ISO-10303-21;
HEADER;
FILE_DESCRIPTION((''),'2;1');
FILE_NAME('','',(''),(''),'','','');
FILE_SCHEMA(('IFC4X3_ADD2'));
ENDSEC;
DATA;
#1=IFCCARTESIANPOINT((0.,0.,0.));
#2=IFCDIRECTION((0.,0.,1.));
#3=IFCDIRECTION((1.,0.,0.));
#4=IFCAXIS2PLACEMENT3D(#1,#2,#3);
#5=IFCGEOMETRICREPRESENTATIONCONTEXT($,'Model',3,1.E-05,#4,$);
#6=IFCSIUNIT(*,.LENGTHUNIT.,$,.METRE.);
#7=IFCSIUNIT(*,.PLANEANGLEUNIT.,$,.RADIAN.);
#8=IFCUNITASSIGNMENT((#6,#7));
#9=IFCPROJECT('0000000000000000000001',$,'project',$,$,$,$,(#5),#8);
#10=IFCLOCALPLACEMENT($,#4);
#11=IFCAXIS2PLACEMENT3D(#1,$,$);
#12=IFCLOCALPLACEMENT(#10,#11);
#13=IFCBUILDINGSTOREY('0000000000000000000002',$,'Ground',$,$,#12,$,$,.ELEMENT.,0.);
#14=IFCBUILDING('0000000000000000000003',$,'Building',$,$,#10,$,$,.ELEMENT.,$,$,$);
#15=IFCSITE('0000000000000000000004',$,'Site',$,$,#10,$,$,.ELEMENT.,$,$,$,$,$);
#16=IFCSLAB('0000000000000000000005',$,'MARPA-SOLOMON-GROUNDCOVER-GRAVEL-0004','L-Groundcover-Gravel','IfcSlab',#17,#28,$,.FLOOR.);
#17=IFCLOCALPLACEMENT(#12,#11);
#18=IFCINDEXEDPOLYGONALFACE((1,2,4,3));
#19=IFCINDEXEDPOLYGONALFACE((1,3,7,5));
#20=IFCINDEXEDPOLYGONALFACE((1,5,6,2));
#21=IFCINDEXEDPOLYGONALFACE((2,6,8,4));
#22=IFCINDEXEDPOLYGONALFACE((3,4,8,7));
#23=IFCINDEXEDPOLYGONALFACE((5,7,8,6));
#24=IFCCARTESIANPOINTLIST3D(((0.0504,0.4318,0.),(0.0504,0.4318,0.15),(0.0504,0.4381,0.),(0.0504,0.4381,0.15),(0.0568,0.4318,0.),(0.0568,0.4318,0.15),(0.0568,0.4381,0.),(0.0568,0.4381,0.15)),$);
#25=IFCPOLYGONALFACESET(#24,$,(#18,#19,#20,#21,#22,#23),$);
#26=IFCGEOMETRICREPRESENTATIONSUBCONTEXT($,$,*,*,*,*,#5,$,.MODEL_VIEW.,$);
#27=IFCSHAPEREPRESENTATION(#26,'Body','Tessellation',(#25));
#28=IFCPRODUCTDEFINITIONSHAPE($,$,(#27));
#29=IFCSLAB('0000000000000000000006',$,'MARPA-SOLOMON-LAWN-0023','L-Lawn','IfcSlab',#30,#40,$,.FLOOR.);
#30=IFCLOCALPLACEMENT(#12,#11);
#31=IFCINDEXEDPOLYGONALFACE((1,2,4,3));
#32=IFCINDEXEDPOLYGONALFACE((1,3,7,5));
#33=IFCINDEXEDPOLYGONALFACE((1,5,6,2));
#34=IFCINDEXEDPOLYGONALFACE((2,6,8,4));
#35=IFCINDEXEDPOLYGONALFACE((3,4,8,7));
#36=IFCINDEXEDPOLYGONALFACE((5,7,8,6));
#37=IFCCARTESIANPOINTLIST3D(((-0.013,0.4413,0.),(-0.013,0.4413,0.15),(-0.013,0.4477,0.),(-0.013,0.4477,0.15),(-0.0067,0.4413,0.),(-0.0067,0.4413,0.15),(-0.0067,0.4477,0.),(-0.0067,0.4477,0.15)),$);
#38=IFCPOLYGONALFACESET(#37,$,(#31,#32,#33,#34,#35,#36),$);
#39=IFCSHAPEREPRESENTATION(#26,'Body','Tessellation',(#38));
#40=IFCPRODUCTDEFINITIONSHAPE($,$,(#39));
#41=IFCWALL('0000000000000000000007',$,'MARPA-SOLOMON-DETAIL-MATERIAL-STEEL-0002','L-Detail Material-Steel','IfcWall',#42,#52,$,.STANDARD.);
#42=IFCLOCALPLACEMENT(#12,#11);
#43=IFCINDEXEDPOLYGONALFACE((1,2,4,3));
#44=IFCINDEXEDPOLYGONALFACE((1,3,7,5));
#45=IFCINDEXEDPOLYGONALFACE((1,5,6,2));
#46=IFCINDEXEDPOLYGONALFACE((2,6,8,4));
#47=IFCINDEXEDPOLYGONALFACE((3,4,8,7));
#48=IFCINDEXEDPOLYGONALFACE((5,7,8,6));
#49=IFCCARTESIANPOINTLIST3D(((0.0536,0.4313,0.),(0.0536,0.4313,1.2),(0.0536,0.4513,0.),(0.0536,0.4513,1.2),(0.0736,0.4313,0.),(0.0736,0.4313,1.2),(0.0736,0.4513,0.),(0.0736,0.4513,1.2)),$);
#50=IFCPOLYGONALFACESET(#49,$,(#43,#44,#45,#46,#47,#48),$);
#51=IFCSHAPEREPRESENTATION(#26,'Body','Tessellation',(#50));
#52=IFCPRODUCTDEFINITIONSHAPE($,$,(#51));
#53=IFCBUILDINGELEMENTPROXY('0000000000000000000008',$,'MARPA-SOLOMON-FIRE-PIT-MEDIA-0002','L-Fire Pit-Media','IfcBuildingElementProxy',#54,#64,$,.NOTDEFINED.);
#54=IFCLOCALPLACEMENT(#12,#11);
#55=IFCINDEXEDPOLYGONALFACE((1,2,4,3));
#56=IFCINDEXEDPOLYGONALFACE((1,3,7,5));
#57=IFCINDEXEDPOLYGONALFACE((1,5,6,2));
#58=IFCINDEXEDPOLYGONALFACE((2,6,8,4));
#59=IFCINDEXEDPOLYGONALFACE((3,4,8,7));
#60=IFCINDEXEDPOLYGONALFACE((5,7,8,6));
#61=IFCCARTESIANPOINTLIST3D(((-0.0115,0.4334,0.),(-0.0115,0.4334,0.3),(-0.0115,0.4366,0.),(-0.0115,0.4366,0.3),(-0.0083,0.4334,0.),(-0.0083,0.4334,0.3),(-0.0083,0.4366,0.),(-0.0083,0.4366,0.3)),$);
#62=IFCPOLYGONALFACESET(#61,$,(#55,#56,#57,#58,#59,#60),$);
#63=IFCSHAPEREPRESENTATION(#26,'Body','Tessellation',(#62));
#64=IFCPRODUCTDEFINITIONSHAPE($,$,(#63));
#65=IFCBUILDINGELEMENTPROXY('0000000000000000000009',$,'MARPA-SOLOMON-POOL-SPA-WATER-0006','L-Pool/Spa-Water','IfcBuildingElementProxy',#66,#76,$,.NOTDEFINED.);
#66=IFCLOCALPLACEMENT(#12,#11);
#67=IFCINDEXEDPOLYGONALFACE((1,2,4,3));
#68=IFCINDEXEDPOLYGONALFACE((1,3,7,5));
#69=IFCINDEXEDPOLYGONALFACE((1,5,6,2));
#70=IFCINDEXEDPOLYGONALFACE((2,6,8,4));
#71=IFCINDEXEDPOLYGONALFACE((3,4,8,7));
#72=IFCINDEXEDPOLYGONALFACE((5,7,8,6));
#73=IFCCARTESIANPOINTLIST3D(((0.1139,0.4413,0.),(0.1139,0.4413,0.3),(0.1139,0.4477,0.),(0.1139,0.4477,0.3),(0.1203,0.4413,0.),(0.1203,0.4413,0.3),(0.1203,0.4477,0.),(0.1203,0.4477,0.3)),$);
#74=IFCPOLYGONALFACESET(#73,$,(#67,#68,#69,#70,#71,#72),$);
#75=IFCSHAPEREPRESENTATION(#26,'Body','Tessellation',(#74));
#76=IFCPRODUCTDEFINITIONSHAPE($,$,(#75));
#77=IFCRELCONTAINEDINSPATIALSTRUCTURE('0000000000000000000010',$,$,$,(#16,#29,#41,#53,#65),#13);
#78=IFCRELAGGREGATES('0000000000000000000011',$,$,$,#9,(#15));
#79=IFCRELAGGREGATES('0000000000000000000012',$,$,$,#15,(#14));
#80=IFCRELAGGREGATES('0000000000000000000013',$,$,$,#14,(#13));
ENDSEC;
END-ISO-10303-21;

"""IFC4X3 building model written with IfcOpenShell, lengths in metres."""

from ifc_helpers import new_model, si_unit, frame, frame_2d, origin, origin_with_axes, place, context, subcontext, project, spatial, polyline, rectangle, outline, extrude, element, save


model = new_model("IFC4X3")

# Units and contexts
model_context = context("Model", 3, precision=1e-05, world=origin_with_axes())
sub_context = subcontext(model_context, None, None, "MODEL_VIEW")
ifc_project = project(units=[si_unit("LENGTHUNIT", "METRE"), si_unit("PLANEANGLEUNIT", "RADIAN")], contexts=[model_context])

# Site, building, storey
placement = place(None, origin_with_axes())
site = spatial("IfcSite", under=ifc_project, at=placement, Name="Site", CompositionType="ELEMENT")
building = spatial("IfcBuilding", under=site, at=placement, Name="Building", CompositionType="ELEMENT")
storey_placement = place(placement, origin())
storey = spatial("IfcBuildingStorey", under=building, at=storey_placement, Name="Ground", CompositionType="ELEMENT", Elevation=0.0)

# Slabs
for number, where, name in (
    (1, (0.0504, 0.4318, 0.0), "MARPA-SOLOMON-GROUNDCOVER-GRAVEL-0004"),
):
    element("IfcSlab", number, at=place(storey_placement, frame(where)), inside=storey, Name=name, Description="L-Groundcover-Gravel", ObjectType="IfcSlab", PredefinedType="FLOOR", context=sub_context, shape_type="SweptSolid", body=[
        extrude(outline(polyline([(0.0, 0.0064), (0.0063, 0.0064), (0.0063, 0.0), (0.0, 0.0), (0.0, 0.0064)])), origin(), (0.0, 0.0, 1.0), 0.15),
    ])
for number, where, name in (
    (2, (-0.013, 0.4413, 0.0), "MARPA-SOLOMON-LAWN-0023"),
):
    element("IfcSlab", number, at=place(storey_placement, frame(where)), inside=storey, Name=name, Description="L-Lawn", ObjectType="IfcSlab", PredefinedType="FLOOR", context=sub_context, shape_type="SweptSolid", body=[
        extrude(outline(polyline([(0.0, 0.0064), (0.0063, 0.0064), (0.0063, 0.0), (0.0, 0.0), (0.0, 0.0064)])), origin(), (0.0, 0.0, 1.0), 0.15),
    ])

# Wall
for number, where, x_axis, name in (
    (3, (0.0536, 0.4413, 0.0), (1.0, 0.0, 0.0), "MARPA-SOLOMON-DETAIL-MATERIAL-STEEL-0002"),
):
    element("IfcWall", number, at=place(storey_placement, frame(where, x_axis=x_axis)), inside=storey, Name=name, Description="L-Detail Material-Steel", ObjectType="IfcWall", PredefinedType="STANDARD", context=sub_context, shape_type="SweptSolid", body=[
        extrude(rectangle(XDim=0.02, YDim=0.02, at=frame_2d((0.01, 0.0))), origin(), (0.0, 0.0, 1.0), 1.2),
    ])

# Building element proxies
for number, where, name in (
    (4, (-0.0115, 0.4334, 0.0), "MARPA-SOLOMON-FIRE-PIT-MEDIA-0002"),
):
    element("IfcBuildingElementProxy", number, at=place(placement, frame(where)), inside=storey, Name=name, Description="L-Fire Pit-Media", ObjectType="IfcBuildingElementProxy", PredefinedType="NOTDEFINED", context=sub_context, shape_type="SweptSolid", body=[
        extrude(outline(polyline([(0.0, 0.0032), (0.0032, 0.0032), (0.0032, 0.0), (0.0, 0.0), (0.0, 0.0032)])), origin(), (0.0, 0.0, 1.0), 0.3),
    ])
for number, where, name in (
    (5, (0.1139, 0.4413, 0.0), "MARPA-SOLOMON-POOL-SPA-WATER-0006"),
):
    element("IfcBuildingElementProxy", number, at=place(placement, frame(where)), inside=storey, Name=name, Description="L-Pool/Spa-Water", ObjectType="IfcBuildingElementProxy", PredefinedType="NOTDEFINED", context=sub_context, shape_type="SweptSolid", body=[
        extrude(outline(polyline([(0.0, 0.0064), (0.0063, 0.0064), (0.0063, 0.0), (0.0, 0.0), (0.0, 0.0064)])), origin(), (0.0, 0.0, 1.0), 0.3),
    ])

save(model, "model.ifc")
